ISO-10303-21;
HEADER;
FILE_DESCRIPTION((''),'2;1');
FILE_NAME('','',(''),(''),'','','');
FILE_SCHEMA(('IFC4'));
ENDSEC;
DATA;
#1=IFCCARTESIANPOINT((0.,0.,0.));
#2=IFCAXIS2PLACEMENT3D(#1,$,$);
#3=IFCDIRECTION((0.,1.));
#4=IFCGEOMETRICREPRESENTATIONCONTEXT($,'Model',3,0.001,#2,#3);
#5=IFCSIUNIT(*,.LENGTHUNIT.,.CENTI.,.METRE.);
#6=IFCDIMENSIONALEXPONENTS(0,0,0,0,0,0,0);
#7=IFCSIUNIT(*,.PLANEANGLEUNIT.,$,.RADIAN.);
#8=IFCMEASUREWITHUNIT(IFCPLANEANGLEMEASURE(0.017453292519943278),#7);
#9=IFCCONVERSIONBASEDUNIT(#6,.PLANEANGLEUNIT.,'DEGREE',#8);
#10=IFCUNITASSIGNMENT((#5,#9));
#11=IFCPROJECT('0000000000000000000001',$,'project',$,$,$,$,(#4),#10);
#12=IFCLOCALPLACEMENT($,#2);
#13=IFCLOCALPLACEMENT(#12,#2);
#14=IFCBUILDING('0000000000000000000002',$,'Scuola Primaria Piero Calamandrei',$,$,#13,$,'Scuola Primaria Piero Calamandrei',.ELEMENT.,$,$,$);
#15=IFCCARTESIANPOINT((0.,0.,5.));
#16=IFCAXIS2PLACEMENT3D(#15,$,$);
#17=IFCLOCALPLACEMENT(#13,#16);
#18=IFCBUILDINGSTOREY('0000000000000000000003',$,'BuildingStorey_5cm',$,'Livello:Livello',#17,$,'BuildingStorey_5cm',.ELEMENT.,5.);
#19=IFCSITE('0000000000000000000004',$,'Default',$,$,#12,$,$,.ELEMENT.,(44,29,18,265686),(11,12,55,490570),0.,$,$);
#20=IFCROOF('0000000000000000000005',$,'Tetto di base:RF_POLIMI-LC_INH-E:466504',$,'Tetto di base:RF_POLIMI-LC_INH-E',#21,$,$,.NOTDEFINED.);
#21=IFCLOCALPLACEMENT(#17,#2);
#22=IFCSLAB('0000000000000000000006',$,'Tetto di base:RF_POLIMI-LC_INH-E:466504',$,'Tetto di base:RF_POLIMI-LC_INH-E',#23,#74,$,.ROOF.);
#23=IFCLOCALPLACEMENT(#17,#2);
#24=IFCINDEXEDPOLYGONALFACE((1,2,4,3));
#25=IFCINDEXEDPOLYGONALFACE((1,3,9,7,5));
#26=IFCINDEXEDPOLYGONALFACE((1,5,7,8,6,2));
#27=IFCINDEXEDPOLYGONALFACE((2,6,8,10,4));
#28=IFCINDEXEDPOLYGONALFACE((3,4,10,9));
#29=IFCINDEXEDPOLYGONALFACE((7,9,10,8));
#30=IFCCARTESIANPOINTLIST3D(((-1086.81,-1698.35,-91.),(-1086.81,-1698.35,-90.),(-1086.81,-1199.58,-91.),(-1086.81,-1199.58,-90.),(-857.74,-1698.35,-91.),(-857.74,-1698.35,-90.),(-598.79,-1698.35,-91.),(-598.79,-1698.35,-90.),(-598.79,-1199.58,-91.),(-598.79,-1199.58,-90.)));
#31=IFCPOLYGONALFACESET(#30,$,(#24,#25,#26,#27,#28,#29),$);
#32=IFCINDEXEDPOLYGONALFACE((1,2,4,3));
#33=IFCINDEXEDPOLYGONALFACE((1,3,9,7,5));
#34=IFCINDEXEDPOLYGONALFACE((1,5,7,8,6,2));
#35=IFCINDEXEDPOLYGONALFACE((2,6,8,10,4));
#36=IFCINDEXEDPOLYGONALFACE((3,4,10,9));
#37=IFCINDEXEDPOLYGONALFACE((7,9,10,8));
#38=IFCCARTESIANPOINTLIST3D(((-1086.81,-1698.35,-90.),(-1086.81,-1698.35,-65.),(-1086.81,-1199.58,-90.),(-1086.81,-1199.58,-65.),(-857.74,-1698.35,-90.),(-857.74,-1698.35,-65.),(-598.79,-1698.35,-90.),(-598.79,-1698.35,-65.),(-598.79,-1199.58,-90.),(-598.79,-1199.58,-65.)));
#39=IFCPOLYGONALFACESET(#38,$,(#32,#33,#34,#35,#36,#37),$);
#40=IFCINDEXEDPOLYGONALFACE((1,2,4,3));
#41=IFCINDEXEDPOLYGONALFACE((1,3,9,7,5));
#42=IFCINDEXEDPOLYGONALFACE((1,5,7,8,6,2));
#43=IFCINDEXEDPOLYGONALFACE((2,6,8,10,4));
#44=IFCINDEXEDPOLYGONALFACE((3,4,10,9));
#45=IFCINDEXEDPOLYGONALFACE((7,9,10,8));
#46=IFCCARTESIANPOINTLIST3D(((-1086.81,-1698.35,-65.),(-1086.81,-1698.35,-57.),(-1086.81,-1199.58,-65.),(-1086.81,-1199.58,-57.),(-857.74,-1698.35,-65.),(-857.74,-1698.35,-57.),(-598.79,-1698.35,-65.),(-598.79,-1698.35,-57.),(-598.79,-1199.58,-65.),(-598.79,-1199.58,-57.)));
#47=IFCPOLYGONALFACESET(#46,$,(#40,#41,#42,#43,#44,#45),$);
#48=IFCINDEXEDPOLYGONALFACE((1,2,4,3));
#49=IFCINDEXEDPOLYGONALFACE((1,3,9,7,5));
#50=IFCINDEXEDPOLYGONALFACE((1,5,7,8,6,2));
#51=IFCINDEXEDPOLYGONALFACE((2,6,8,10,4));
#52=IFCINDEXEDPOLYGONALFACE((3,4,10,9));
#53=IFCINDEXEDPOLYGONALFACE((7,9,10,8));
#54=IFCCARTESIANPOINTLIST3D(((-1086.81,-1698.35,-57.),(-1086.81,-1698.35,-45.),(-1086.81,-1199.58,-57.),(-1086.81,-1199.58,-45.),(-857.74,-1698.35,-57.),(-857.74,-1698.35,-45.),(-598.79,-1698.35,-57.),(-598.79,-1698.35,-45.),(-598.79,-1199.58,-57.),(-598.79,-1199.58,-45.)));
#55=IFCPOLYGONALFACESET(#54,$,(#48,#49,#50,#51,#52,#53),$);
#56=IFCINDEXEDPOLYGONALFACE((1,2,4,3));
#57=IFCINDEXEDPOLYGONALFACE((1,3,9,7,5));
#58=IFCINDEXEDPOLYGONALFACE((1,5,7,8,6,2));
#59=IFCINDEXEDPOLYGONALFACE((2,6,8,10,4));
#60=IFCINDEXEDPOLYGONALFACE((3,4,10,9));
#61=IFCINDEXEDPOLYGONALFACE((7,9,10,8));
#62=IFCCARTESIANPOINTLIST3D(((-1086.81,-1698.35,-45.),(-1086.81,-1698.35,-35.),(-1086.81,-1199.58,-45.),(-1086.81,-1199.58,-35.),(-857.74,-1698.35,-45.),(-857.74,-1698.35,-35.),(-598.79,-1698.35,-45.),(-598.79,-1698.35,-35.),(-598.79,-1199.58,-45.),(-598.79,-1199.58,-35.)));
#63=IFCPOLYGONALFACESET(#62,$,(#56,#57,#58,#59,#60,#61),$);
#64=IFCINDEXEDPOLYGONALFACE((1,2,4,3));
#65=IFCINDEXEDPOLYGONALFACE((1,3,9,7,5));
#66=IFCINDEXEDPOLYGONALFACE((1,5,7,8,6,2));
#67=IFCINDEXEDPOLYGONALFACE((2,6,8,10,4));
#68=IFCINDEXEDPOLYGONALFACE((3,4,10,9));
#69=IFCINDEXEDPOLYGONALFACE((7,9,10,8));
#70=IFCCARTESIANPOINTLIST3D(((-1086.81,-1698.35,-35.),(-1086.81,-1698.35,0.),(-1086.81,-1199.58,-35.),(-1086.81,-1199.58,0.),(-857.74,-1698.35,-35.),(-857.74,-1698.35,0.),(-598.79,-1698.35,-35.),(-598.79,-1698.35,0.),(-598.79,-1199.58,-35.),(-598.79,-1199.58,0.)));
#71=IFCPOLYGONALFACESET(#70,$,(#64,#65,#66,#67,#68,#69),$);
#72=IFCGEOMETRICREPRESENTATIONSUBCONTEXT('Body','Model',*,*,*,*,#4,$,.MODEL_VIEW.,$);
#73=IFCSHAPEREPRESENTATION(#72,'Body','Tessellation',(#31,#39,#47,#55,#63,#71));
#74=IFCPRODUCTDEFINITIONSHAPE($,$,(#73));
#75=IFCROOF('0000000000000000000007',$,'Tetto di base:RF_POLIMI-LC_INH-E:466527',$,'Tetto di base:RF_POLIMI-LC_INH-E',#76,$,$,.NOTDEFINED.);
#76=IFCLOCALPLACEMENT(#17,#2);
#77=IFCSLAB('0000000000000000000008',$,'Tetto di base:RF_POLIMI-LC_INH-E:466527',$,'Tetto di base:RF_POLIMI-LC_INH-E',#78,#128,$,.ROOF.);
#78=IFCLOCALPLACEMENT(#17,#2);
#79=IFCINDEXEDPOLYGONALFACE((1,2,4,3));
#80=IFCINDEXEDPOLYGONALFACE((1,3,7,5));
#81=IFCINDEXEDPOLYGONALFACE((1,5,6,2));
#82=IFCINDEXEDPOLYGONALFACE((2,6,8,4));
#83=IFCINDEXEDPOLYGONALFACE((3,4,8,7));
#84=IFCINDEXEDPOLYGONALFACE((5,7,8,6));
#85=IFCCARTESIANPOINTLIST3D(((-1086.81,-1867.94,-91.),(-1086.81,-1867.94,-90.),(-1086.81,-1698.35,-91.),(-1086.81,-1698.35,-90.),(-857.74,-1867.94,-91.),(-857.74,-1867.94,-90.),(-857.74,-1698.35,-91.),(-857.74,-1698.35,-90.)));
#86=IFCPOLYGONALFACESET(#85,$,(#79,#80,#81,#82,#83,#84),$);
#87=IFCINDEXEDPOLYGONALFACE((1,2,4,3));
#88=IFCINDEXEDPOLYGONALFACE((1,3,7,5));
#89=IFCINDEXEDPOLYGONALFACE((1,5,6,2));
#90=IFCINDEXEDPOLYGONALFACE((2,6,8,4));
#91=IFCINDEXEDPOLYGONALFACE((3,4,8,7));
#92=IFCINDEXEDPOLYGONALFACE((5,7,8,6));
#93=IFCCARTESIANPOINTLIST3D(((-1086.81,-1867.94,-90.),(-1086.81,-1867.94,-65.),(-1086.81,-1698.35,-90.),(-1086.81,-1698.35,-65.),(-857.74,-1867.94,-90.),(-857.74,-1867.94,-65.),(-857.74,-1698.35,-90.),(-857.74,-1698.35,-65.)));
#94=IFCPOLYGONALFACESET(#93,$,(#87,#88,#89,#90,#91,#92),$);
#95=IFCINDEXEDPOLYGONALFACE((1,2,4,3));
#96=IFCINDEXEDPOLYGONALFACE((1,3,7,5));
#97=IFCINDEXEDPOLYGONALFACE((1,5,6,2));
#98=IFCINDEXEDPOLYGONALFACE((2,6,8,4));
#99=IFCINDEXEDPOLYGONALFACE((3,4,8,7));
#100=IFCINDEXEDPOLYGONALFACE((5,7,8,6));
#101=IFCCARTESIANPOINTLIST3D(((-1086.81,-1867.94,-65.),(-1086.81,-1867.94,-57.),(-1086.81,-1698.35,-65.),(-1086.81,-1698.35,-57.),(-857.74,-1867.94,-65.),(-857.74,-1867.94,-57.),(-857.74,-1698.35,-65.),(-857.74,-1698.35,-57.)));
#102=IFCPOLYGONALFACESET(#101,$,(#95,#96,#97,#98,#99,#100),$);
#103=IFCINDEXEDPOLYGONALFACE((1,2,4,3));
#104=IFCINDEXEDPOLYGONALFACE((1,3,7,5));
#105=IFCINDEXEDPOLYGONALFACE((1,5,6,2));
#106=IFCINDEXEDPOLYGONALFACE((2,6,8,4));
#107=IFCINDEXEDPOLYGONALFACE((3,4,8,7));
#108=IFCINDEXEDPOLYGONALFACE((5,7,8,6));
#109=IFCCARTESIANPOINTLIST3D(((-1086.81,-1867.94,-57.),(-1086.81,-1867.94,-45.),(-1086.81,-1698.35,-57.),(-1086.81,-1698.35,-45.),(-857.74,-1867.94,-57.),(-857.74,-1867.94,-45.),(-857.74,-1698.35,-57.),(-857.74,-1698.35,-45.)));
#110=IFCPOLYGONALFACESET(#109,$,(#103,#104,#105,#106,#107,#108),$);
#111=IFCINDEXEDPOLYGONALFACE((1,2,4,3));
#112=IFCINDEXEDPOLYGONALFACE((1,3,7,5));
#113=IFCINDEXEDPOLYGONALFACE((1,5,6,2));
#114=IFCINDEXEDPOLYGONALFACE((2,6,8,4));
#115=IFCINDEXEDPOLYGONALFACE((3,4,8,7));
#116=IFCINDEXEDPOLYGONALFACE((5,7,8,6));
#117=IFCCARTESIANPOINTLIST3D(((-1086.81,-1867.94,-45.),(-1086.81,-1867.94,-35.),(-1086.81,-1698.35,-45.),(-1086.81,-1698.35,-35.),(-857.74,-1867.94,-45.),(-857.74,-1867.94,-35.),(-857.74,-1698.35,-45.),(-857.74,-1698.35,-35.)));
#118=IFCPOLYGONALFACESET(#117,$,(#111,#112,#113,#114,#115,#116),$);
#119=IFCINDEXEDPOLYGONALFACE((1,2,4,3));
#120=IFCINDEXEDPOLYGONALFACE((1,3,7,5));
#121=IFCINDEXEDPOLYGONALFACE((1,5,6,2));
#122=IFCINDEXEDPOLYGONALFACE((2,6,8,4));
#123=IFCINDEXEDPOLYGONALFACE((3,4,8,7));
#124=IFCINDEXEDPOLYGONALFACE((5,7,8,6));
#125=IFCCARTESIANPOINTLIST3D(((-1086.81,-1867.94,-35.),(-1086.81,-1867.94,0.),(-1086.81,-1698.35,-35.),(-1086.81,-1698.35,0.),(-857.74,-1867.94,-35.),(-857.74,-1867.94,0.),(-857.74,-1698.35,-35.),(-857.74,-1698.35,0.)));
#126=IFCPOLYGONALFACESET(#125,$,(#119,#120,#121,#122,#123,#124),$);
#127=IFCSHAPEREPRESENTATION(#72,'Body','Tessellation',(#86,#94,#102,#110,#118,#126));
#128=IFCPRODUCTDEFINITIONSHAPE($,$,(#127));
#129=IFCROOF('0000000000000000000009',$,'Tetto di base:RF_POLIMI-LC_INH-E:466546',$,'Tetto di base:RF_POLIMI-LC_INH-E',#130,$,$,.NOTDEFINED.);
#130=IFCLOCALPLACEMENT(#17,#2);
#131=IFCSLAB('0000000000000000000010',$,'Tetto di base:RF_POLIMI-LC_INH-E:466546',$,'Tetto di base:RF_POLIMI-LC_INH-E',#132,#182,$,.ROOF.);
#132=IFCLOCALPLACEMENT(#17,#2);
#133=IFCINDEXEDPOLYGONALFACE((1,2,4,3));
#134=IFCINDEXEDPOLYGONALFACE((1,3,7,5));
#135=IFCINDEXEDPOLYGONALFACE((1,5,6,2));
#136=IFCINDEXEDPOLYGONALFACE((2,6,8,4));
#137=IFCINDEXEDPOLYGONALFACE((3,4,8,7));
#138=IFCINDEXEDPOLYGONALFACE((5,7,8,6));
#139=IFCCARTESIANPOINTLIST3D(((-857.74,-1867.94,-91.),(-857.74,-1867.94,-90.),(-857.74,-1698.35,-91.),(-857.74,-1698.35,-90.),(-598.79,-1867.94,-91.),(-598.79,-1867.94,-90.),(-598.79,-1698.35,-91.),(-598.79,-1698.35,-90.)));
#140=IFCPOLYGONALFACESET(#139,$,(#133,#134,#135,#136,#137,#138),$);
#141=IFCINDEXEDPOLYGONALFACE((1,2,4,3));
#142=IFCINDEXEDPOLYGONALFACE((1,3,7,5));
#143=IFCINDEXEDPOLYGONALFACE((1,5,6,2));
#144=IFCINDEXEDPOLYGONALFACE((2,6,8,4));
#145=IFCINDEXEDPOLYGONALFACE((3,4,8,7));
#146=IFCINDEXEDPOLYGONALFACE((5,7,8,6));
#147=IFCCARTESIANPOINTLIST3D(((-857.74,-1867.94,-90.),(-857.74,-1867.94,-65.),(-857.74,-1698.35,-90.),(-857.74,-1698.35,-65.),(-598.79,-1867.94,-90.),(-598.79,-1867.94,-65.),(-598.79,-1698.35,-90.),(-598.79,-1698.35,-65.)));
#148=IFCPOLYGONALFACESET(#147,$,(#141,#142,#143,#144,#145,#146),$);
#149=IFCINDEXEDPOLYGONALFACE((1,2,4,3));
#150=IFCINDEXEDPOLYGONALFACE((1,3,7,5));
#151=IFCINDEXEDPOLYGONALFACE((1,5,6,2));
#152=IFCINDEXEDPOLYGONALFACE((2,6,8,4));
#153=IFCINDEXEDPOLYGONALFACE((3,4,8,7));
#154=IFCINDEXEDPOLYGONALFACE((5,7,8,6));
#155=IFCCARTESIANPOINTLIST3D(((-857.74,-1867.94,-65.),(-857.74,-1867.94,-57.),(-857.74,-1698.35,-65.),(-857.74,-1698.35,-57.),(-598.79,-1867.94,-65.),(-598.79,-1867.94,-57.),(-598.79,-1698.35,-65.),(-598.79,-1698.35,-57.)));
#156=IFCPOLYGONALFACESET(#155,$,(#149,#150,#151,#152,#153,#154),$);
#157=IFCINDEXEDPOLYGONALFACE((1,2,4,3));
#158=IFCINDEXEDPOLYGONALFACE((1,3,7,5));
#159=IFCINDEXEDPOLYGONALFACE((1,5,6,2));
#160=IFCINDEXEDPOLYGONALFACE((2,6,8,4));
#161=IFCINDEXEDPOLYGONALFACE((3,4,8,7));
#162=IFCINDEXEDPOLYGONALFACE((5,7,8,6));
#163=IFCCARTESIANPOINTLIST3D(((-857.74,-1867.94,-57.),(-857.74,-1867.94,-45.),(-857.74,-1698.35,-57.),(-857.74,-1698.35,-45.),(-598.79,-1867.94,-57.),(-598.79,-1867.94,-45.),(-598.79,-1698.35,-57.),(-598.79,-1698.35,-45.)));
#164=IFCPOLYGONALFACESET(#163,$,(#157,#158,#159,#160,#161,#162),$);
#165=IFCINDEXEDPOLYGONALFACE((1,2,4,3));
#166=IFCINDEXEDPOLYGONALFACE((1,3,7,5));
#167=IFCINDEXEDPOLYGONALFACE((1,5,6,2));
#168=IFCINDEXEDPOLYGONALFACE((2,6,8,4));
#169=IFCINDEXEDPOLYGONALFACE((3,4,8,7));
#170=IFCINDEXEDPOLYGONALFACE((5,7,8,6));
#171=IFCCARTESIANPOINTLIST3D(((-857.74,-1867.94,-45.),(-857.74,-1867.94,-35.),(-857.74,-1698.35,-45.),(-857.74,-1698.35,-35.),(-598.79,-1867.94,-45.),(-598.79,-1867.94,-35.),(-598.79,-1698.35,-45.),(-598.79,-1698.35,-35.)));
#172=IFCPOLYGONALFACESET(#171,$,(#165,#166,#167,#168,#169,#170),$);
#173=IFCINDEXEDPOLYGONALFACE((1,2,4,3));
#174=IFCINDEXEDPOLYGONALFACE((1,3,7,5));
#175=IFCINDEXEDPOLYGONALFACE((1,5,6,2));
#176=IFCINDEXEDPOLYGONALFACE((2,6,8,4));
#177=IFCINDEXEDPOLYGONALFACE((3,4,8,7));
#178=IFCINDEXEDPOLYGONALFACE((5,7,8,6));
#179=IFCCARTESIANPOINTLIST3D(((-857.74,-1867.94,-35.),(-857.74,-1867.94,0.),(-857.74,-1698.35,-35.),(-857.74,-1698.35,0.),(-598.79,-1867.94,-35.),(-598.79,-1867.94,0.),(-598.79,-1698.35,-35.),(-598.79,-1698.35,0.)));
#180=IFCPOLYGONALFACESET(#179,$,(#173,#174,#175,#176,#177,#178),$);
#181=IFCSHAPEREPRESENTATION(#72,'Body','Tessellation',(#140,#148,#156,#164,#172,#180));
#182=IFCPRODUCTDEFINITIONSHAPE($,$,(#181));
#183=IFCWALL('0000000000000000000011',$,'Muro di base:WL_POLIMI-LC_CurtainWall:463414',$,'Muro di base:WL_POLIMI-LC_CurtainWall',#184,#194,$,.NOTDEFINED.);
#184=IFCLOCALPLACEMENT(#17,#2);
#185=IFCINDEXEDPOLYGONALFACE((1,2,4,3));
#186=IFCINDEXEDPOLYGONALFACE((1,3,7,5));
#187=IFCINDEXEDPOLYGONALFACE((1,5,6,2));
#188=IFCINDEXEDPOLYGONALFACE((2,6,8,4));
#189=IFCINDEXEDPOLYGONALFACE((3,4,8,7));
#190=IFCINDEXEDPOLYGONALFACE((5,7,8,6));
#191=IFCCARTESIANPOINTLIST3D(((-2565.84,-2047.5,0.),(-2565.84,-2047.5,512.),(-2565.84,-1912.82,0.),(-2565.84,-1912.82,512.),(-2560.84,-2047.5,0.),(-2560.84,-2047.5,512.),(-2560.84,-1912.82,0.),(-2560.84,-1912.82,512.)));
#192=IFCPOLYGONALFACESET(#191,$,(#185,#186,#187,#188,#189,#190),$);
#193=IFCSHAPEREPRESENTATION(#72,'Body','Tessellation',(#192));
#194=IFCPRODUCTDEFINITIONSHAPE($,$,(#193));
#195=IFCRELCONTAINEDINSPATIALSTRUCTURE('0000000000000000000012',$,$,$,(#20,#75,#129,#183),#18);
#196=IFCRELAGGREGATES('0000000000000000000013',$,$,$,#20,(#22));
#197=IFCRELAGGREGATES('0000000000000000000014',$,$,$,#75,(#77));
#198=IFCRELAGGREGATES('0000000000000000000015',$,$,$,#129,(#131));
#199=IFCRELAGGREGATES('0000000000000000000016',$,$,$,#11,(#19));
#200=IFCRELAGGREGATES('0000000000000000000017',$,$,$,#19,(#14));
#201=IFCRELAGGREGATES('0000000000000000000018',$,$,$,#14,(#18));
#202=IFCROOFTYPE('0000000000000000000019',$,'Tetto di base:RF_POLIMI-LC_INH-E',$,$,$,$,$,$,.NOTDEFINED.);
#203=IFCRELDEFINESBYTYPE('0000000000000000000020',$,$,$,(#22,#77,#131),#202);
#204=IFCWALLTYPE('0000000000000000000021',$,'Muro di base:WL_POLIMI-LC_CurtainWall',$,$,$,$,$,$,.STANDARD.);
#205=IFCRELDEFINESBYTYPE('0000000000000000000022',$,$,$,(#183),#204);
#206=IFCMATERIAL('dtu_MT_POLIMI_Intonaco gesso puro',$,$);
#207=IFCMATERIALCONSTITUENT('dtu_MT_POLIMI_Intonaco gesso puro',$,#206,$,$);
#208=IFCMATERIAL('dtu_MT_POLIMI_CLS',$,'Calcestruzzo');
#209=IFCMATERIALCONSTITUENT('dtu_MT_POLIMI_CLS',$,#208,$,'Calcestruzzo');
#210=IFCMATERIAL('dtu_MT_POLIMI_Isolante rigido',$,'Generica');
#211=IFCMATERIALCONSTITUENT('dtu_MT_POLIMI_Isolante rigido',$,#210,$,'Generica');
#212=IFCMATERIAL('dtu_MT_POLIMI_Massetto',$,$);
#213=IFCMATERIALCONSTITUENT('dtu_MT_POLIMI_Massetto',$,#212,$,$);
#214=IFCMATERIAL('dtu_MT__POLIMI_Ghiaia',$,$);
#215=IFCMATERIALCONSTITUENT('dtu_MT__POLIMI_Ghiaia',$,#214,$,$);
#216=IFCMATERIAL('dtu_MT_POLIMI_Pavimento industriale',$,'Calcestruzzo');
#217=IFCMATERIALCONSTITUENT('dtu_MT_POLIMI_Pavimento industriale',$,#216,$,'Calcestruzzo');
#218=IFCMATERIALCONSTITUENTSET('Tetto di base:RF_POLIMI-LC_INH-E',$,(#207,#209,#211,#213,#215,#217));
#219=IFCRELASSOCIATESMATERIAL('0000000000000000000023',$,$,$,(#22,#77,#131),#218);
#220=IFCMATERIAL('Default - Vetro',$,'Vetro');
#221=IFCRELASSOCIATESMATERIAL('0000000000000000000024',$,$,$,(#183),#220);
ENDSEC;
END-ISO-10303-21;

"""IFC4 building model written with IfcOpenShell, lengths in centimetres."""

from ifc_helpers import new_model, entity, si_unit, converted_unit, direction, frame, origin, place, context, subcontext, project, spatial, indexed_curve, outline, extrude, material, constituent, constituent_set, type_object, element, aggregate, save


model = new_model("IFC4")

# Units and contexts
model_context = context("Model", 3, precision=0.001, world=origin(), true_north=direction((0.0, 1.0)))
body_context = subcontext(model_context, "Body", "Model", "MODEL_VIEW")
ifc_project = project(units=[si_unit("LENGTHUNIT", "METRE", prefix="CENTI"), converted_unit("PLANEANGLEUNIT", "DEGREE", entity("IfcPlaneAngleMeasure", 0.017453292519943278), si_unit("PLANEANGLEUNIT", "RADIAN"), dimensions=[0, 0, 0, 0, 0, 0, 0])], contexts=[model_context])

# Site, building, storey
site_placement = place(None, origin())
site = spatial("IfcSite", under=ifc_project, at=site_placement, Name="Default", CompositionType="ELEMENT", RefLatitude=(44, 29, 18, 265686), RefLongitude=(11, 12, 55, 490570), RefElevation=0.0)
building_placement = place(site_placement, origin())
building = spatial("IfcBuilding", under=site, at=building_placement, Name="Scuola Primaria Piero Calamandrei", LongName="Scuola Primaria Piero Calamandrei", CompositionType="ELEMENT")
storey_placement = place(building_placement, frame((0.0, 0.0, 5.0)))
storey = spatial("IfcBuildingStorey", under=building, at=storey_placement, Name="BuildingStorey_5cm", ObjectType="Livello:Livello", LongName="BuildingStorey_5cm", CompositionType="ELEMENT", Elevation=5.0)

# Roofs, slabs
ifc_material_1 = material(Name="dtu_MT_POLIMI_Intonaco gesso puro")
ifc_constituent_1 = constituent(ifc_material_1, Name="dtu_MT_POLIMI_Intonaco gesso puro")
ifc_material_2 = material(Name="dtu_MT_POLIMI_CLS", Category="Calcestruzzo")
ifc_constituent_2 = constituent(ifc_material_2, Name="dtu_MT_POLIMI_CLS", Category="Calcestruzzo")
ifc_material_3 = material(Name="dtu_MT_POLIMI_Isolante rigido", Category="Generica")
ifc_constituent_3 = constituent(ifc_material_3, Name="dtu_MT_POLIMI_Isolante rigido", Category="Generica")
ifc_material_4 = material(Name="dtu_MT_POLIMI_Massetto")
ifc_constituent_4 = constituent(ifc_material_4, Name="dtu_MT_POLIMI_Massetto")
ifc_material_5 = material(Name="dtu_MT__POLIMI_Ghiaia")
ifc_constituent_5 = constituent(ifc_material_5, Name="dtu_MT__POLIMI_Ghiaia")
ifc_material_6 = material(Name="dtu_MT_POLIMI_Pavimento industriale", Category="Calcestruzzo")
ifc_constituent_6 = constituent(ifc_material_6, Name="dtu_MT_POLIMI_Pavimento industriale", Category="Calcestruzzo")
ifc_constituent_set_1 = constituent_set(constituents=[ifc_constituent_1, ifc_constituent_2, ifc_constituent_3, ifc_constituent_4, ifc_constituent_5, ifc_constituent_6], Name="Tetto di base:RF_POLIMI-LC_INH-E")
roof_type = type_object("IfcRoofType", Name="Tetto di base:RF_POLIMI-LC_INH-E", PredefinedType="NOTDEFINED")
roof_1_placement = place(storey_placement, frame((-1086.81, -1698.35, -91.0)))
roof_1 = element("IfcRoof", 1, at=roof_1_placement, inside=storey, Name="Tetto di base:RF_POLIMI-LC_INH-E:466504", ObjectType="Tetto di base:RF_POLIMI-LC_INH-E", PredefinedType="NOTDEFINED")
slab_1_placement = place(roof_1_placement, origin())
slab_1 = element("IfcSlab", 2, at=slab_1_placement, type_object=roof_type, material=ifc_constituent_set_1, Name="Tetto di base:RF_POLIMI-LC_INH-E:466504", ObjectType="Tetto di base:RF_POLIMI-LC_INH-E", PredefinedType="ROOF", context=body_context, shape_type="SweptSolid", body=[
    extrude(outline(indexed_curve([(244.01, 249.39), (-244.01, 249.39), (-244.01, -249.39), (-14.94, -249.39), (244.01, -249.39), (244.01, 249.39)], self_intersect=False)), frame((244.01, 249.39, 0.0)), (0.0, 0.0, 1.0), 1.0),
    extrude(outline(indexed_curve([(244.01, 249.39), (-244.01, 249.39), (-244.01, -249.39), (-14.94, -249.39), (244.01, -249.39), (244.01, 249.39)], self_intersect=False)), frame((244.01, 249.39, 1.0)), (0.0, 0.0, 1.0), 25.0),
    extrude(outline(indexed_curve([(244.01, 249.39), (-244.01, 249.39), (-244.01, -249.39), (-14.94, -249.39), (244.01, -249.39), (244.01, 249.39)], self_intersect=False)), frame((244.01, 249.39, 26.0)), (0.0, 0.0, 1.0), 8.0),
    extrude(outline(indexed_curve([(244.01, 249.39), (-244.01, 249.39), (-244.01, -249.39), (-14.94, -249.39), (244.01, -249.39), (244.01, 249.39)], self_intersect=False)), frame((244.01, 249.39, 34.0)), (0.0, 0.0, 1.0), 12.0),
    extrude(outline(indexed_curve([(244.01, 249.39), (-244.01, 249.39), (-244.01, -249.39), (-14.94, -249.39), (244.01, -249.39), (244.01, 249.39)], self_intersect=False)), frame((244.01, 249.39, 46.0)), (0.0, 0.0, 1.0), 10.0),
    extrude(outline(indexed_curve([(244.01, 249.39), (-244.01, 249.39), (-244.01, -249.39), (-14.94, -249.39), (244.01, -249.39), (244.01, 249.39)], self_intersect=False)), frame((244.01, 249.39, 56.0)), (0.0, 0.0, 1.0), 35.0),
])
aggregate(roof_1, [slab_1])
roof_2_placement = place(storey_placement, frame((-1086.81, -1867.94, -91.0)))
roof_2 = element("IfcRoof", 3, at=roof_2_placement, inside=storey, Name="Tetto di base:RF_POLIMI-LC_INH-E:466527", ObjectType="Tetto di base:RF_POLIMI-LC_INH-E", PredefinedType="NOTDEFINED")
slab_2_placement = place(roof_2_placement, origin())
slab_2 = element("IfcSlab", 4, at=slab_2_placement, type_object=roof_type, material=ifc_constituent_set_1, Name="Tetto di base:RF_POLIMI-LC_INH-E:466527", ObjectType="Tetto di base:RF_POLIMI-LC_INH-E", PredefinedType="ROOF", context=body_context, shape_type="SweptSolid", body=[
    extrude(outline(indexed_curve([(114.54, 84.79), (-114.54, 84.79), (-114.54, -84.79), (114.54, -84.79), (114.54, 84.79)], self_intersect=False)), frame((114.54, 84.79, 0.0)), (0.0, 0.0, 1.0), 1.0),
    extrude(outline(indexed_curve([(114.54, 84.79), (-114.54, 84.79), (-114.54, -84.79), (114.54, -84.79), (114.54, 84.79)], self_intersect=False)), frame((114.54, 84.79, 1.0)), (0.0, 0.0, 1.0), 25.0),
    extrude(outline(indexed_curve([(114.54, 84.79), (-114.54, 84.79), (-114.54, -84.79), (114.54, -84.79), (114.54, 84.79)], self_intersect=False)), frame((114.54, 84.79, 26.0)), (0.0, 0.0, 1.0), 8.0),
    extrude(outline(indexed_curve([(114.54, 84.79), (-114.54, 84.79), (-114.54, -84.79), (114.54, -84.79), (114.54, 84.79)], self_intersect=False)), frame((114.54, 84.79, 34.0)), (0.0, 0.0, 1.0), 12.0),
    extrude(outline(indexed_curve([(114.54, 84.79), (-114.54, 84.79), (-114.54, -84.79), (114.54, -84.79), (114.54, 84.79)], self_intersect=False)), frame((114.54, 84.79, 46.0)), (0.0, 0.0, 1.0), 10.0),
    extrude(outline(indexed_curve([(114.54, 84.79), (-114.54, 84.79), (-114.54, -84.79), (114.54, -84.79), (114.54, 84.79)], self_intersect=False)), frame((114.54, 84.79, 56.0)), (0.0, 0.0, 1.0), 35.0),
])
aggregate(roof_2, [slab_2])
roof_3_placement = place(storey_placement, frame((-857.74, -1867.94, -91.0)))
roof_3 = element("IfcRoof", 5, at=roof_3_placement, inside=storey, Name="Tetto di base:RF_POLIMI-LC_INH-E:466546", ObjectType="Tetto di base:RF_POLIMI-LC_INH-E", PredefinedType="NOTDEFINED")
slab_3_placement = place(roof_3_placement, origin())
slab_3 = element("IfcSlab", 6, at=slab_3_placement, type_object=roof_type, material=ifc_constituent_set_1, Name="Tetto di base:RF_POLIMI-LC_INH-E:466546", ObjectType="Tetto di base:RF_POLIMI-LC_INH-E", PredefinedType="ROOF", context=body_context, shape_type="SweptSolid", body=[
    extrude(outline(indexed_curve([(129.48, 84.79), (-129.48, 84.79), (-129.48, -84.79), (129.48, -84.79), (129.48, 84.79)], self_intersect=False)), frame((129.48, 84.79, 0.0)), (0.0, 0.0, 1.0), 1.0),
    extrude(outline(indexed_curve([(129.48, 84.79), (-129.48, 84.79), (-129.48, -84.79), (129.48, -84.79), (129.48, 84.79)], self_intersect=False)), frame((129.48, 84.79, 1.0)), (0.0, 0.0, 1.0), 25.0),
    extrude(outline(indexed_curve([(129.48, 84.79), (-129.48, 84.79), (-129.48, -84.79), (129.48, -84.79), (129.48, 84.79)], self_intersect=False)), frame((129.48, 84.79, 26.0)), (0.0, 0.0, 1.0), 8.0),
    extrude(outline(indexed_curve([(129.48, 84.79), (-129.48, 84.79), (-129.48, -84.79), (129.48, -84.79), (129.48, 84.79)], self_intersect=False)), frame((129.48, 84.79, 34.0)), (0.0, 0.0, 1.0), 12.0),
    extrude(outline(indexed_curve([(129.48, 84.79), (-129.48, 84.79), (-129.48, -84.79), (129.48, -84.79), (129.48, 84.79)], self_intersect=False)), frame((129.48, 84.79, 46.0)), (0.0, 0.0, 1.0), 10.0),
    extrude(outline(indexed_curve([(129.48, 84.79), (-129.48, 84.79), (-129.48, -84.79), (129.48, -84.79), (129.48, 84.79)], self_intersect=False)), frame((129.48, 84.79, 56.0)), (0.0, 0.0, 1.0), 35.0),
])
aggregate(roof_3, [slab_3])

# Wall
ifc_material_7 = material(Name="Default - Vetro", Category="Vetro")
wall_type_1 = type_object("IfcWallType", Name="Muro di base:WL_POLIMI-LC_CurtainWall", PredefinedType="STANDARD")
wall_1_placement = place(storey_placement, frame((-2563.34, -1912.82, 0.0), z_axis=(0.0, 0.0, 1.0), x_axis=(0.0, -1.0, 0.0)))
element("IfcWall", 7, at=wall_1_placement, inside=storey, type_object=wall_type_1, material=ifc_material_7, Name="Muro di base:WL_POLIMI-LC_CurtainWall:463414", ObjectType="Muro di base:WL_POLIMI-LC_CurtainWall", PredefinedType="NOTDEFINED", context=body_context, shape_type="SweptSolid", body=[
    extrude(outline(indexed_curve([(134.68, 2.5), (0.0, 2.5), (0.0, -2.5), (134.68, -2.5), (134.68, 2.5)], self_intersect=False)), origin(), (0.0, 0.0, 1.0), 512.0),
])

save(model, "model.ifc")
